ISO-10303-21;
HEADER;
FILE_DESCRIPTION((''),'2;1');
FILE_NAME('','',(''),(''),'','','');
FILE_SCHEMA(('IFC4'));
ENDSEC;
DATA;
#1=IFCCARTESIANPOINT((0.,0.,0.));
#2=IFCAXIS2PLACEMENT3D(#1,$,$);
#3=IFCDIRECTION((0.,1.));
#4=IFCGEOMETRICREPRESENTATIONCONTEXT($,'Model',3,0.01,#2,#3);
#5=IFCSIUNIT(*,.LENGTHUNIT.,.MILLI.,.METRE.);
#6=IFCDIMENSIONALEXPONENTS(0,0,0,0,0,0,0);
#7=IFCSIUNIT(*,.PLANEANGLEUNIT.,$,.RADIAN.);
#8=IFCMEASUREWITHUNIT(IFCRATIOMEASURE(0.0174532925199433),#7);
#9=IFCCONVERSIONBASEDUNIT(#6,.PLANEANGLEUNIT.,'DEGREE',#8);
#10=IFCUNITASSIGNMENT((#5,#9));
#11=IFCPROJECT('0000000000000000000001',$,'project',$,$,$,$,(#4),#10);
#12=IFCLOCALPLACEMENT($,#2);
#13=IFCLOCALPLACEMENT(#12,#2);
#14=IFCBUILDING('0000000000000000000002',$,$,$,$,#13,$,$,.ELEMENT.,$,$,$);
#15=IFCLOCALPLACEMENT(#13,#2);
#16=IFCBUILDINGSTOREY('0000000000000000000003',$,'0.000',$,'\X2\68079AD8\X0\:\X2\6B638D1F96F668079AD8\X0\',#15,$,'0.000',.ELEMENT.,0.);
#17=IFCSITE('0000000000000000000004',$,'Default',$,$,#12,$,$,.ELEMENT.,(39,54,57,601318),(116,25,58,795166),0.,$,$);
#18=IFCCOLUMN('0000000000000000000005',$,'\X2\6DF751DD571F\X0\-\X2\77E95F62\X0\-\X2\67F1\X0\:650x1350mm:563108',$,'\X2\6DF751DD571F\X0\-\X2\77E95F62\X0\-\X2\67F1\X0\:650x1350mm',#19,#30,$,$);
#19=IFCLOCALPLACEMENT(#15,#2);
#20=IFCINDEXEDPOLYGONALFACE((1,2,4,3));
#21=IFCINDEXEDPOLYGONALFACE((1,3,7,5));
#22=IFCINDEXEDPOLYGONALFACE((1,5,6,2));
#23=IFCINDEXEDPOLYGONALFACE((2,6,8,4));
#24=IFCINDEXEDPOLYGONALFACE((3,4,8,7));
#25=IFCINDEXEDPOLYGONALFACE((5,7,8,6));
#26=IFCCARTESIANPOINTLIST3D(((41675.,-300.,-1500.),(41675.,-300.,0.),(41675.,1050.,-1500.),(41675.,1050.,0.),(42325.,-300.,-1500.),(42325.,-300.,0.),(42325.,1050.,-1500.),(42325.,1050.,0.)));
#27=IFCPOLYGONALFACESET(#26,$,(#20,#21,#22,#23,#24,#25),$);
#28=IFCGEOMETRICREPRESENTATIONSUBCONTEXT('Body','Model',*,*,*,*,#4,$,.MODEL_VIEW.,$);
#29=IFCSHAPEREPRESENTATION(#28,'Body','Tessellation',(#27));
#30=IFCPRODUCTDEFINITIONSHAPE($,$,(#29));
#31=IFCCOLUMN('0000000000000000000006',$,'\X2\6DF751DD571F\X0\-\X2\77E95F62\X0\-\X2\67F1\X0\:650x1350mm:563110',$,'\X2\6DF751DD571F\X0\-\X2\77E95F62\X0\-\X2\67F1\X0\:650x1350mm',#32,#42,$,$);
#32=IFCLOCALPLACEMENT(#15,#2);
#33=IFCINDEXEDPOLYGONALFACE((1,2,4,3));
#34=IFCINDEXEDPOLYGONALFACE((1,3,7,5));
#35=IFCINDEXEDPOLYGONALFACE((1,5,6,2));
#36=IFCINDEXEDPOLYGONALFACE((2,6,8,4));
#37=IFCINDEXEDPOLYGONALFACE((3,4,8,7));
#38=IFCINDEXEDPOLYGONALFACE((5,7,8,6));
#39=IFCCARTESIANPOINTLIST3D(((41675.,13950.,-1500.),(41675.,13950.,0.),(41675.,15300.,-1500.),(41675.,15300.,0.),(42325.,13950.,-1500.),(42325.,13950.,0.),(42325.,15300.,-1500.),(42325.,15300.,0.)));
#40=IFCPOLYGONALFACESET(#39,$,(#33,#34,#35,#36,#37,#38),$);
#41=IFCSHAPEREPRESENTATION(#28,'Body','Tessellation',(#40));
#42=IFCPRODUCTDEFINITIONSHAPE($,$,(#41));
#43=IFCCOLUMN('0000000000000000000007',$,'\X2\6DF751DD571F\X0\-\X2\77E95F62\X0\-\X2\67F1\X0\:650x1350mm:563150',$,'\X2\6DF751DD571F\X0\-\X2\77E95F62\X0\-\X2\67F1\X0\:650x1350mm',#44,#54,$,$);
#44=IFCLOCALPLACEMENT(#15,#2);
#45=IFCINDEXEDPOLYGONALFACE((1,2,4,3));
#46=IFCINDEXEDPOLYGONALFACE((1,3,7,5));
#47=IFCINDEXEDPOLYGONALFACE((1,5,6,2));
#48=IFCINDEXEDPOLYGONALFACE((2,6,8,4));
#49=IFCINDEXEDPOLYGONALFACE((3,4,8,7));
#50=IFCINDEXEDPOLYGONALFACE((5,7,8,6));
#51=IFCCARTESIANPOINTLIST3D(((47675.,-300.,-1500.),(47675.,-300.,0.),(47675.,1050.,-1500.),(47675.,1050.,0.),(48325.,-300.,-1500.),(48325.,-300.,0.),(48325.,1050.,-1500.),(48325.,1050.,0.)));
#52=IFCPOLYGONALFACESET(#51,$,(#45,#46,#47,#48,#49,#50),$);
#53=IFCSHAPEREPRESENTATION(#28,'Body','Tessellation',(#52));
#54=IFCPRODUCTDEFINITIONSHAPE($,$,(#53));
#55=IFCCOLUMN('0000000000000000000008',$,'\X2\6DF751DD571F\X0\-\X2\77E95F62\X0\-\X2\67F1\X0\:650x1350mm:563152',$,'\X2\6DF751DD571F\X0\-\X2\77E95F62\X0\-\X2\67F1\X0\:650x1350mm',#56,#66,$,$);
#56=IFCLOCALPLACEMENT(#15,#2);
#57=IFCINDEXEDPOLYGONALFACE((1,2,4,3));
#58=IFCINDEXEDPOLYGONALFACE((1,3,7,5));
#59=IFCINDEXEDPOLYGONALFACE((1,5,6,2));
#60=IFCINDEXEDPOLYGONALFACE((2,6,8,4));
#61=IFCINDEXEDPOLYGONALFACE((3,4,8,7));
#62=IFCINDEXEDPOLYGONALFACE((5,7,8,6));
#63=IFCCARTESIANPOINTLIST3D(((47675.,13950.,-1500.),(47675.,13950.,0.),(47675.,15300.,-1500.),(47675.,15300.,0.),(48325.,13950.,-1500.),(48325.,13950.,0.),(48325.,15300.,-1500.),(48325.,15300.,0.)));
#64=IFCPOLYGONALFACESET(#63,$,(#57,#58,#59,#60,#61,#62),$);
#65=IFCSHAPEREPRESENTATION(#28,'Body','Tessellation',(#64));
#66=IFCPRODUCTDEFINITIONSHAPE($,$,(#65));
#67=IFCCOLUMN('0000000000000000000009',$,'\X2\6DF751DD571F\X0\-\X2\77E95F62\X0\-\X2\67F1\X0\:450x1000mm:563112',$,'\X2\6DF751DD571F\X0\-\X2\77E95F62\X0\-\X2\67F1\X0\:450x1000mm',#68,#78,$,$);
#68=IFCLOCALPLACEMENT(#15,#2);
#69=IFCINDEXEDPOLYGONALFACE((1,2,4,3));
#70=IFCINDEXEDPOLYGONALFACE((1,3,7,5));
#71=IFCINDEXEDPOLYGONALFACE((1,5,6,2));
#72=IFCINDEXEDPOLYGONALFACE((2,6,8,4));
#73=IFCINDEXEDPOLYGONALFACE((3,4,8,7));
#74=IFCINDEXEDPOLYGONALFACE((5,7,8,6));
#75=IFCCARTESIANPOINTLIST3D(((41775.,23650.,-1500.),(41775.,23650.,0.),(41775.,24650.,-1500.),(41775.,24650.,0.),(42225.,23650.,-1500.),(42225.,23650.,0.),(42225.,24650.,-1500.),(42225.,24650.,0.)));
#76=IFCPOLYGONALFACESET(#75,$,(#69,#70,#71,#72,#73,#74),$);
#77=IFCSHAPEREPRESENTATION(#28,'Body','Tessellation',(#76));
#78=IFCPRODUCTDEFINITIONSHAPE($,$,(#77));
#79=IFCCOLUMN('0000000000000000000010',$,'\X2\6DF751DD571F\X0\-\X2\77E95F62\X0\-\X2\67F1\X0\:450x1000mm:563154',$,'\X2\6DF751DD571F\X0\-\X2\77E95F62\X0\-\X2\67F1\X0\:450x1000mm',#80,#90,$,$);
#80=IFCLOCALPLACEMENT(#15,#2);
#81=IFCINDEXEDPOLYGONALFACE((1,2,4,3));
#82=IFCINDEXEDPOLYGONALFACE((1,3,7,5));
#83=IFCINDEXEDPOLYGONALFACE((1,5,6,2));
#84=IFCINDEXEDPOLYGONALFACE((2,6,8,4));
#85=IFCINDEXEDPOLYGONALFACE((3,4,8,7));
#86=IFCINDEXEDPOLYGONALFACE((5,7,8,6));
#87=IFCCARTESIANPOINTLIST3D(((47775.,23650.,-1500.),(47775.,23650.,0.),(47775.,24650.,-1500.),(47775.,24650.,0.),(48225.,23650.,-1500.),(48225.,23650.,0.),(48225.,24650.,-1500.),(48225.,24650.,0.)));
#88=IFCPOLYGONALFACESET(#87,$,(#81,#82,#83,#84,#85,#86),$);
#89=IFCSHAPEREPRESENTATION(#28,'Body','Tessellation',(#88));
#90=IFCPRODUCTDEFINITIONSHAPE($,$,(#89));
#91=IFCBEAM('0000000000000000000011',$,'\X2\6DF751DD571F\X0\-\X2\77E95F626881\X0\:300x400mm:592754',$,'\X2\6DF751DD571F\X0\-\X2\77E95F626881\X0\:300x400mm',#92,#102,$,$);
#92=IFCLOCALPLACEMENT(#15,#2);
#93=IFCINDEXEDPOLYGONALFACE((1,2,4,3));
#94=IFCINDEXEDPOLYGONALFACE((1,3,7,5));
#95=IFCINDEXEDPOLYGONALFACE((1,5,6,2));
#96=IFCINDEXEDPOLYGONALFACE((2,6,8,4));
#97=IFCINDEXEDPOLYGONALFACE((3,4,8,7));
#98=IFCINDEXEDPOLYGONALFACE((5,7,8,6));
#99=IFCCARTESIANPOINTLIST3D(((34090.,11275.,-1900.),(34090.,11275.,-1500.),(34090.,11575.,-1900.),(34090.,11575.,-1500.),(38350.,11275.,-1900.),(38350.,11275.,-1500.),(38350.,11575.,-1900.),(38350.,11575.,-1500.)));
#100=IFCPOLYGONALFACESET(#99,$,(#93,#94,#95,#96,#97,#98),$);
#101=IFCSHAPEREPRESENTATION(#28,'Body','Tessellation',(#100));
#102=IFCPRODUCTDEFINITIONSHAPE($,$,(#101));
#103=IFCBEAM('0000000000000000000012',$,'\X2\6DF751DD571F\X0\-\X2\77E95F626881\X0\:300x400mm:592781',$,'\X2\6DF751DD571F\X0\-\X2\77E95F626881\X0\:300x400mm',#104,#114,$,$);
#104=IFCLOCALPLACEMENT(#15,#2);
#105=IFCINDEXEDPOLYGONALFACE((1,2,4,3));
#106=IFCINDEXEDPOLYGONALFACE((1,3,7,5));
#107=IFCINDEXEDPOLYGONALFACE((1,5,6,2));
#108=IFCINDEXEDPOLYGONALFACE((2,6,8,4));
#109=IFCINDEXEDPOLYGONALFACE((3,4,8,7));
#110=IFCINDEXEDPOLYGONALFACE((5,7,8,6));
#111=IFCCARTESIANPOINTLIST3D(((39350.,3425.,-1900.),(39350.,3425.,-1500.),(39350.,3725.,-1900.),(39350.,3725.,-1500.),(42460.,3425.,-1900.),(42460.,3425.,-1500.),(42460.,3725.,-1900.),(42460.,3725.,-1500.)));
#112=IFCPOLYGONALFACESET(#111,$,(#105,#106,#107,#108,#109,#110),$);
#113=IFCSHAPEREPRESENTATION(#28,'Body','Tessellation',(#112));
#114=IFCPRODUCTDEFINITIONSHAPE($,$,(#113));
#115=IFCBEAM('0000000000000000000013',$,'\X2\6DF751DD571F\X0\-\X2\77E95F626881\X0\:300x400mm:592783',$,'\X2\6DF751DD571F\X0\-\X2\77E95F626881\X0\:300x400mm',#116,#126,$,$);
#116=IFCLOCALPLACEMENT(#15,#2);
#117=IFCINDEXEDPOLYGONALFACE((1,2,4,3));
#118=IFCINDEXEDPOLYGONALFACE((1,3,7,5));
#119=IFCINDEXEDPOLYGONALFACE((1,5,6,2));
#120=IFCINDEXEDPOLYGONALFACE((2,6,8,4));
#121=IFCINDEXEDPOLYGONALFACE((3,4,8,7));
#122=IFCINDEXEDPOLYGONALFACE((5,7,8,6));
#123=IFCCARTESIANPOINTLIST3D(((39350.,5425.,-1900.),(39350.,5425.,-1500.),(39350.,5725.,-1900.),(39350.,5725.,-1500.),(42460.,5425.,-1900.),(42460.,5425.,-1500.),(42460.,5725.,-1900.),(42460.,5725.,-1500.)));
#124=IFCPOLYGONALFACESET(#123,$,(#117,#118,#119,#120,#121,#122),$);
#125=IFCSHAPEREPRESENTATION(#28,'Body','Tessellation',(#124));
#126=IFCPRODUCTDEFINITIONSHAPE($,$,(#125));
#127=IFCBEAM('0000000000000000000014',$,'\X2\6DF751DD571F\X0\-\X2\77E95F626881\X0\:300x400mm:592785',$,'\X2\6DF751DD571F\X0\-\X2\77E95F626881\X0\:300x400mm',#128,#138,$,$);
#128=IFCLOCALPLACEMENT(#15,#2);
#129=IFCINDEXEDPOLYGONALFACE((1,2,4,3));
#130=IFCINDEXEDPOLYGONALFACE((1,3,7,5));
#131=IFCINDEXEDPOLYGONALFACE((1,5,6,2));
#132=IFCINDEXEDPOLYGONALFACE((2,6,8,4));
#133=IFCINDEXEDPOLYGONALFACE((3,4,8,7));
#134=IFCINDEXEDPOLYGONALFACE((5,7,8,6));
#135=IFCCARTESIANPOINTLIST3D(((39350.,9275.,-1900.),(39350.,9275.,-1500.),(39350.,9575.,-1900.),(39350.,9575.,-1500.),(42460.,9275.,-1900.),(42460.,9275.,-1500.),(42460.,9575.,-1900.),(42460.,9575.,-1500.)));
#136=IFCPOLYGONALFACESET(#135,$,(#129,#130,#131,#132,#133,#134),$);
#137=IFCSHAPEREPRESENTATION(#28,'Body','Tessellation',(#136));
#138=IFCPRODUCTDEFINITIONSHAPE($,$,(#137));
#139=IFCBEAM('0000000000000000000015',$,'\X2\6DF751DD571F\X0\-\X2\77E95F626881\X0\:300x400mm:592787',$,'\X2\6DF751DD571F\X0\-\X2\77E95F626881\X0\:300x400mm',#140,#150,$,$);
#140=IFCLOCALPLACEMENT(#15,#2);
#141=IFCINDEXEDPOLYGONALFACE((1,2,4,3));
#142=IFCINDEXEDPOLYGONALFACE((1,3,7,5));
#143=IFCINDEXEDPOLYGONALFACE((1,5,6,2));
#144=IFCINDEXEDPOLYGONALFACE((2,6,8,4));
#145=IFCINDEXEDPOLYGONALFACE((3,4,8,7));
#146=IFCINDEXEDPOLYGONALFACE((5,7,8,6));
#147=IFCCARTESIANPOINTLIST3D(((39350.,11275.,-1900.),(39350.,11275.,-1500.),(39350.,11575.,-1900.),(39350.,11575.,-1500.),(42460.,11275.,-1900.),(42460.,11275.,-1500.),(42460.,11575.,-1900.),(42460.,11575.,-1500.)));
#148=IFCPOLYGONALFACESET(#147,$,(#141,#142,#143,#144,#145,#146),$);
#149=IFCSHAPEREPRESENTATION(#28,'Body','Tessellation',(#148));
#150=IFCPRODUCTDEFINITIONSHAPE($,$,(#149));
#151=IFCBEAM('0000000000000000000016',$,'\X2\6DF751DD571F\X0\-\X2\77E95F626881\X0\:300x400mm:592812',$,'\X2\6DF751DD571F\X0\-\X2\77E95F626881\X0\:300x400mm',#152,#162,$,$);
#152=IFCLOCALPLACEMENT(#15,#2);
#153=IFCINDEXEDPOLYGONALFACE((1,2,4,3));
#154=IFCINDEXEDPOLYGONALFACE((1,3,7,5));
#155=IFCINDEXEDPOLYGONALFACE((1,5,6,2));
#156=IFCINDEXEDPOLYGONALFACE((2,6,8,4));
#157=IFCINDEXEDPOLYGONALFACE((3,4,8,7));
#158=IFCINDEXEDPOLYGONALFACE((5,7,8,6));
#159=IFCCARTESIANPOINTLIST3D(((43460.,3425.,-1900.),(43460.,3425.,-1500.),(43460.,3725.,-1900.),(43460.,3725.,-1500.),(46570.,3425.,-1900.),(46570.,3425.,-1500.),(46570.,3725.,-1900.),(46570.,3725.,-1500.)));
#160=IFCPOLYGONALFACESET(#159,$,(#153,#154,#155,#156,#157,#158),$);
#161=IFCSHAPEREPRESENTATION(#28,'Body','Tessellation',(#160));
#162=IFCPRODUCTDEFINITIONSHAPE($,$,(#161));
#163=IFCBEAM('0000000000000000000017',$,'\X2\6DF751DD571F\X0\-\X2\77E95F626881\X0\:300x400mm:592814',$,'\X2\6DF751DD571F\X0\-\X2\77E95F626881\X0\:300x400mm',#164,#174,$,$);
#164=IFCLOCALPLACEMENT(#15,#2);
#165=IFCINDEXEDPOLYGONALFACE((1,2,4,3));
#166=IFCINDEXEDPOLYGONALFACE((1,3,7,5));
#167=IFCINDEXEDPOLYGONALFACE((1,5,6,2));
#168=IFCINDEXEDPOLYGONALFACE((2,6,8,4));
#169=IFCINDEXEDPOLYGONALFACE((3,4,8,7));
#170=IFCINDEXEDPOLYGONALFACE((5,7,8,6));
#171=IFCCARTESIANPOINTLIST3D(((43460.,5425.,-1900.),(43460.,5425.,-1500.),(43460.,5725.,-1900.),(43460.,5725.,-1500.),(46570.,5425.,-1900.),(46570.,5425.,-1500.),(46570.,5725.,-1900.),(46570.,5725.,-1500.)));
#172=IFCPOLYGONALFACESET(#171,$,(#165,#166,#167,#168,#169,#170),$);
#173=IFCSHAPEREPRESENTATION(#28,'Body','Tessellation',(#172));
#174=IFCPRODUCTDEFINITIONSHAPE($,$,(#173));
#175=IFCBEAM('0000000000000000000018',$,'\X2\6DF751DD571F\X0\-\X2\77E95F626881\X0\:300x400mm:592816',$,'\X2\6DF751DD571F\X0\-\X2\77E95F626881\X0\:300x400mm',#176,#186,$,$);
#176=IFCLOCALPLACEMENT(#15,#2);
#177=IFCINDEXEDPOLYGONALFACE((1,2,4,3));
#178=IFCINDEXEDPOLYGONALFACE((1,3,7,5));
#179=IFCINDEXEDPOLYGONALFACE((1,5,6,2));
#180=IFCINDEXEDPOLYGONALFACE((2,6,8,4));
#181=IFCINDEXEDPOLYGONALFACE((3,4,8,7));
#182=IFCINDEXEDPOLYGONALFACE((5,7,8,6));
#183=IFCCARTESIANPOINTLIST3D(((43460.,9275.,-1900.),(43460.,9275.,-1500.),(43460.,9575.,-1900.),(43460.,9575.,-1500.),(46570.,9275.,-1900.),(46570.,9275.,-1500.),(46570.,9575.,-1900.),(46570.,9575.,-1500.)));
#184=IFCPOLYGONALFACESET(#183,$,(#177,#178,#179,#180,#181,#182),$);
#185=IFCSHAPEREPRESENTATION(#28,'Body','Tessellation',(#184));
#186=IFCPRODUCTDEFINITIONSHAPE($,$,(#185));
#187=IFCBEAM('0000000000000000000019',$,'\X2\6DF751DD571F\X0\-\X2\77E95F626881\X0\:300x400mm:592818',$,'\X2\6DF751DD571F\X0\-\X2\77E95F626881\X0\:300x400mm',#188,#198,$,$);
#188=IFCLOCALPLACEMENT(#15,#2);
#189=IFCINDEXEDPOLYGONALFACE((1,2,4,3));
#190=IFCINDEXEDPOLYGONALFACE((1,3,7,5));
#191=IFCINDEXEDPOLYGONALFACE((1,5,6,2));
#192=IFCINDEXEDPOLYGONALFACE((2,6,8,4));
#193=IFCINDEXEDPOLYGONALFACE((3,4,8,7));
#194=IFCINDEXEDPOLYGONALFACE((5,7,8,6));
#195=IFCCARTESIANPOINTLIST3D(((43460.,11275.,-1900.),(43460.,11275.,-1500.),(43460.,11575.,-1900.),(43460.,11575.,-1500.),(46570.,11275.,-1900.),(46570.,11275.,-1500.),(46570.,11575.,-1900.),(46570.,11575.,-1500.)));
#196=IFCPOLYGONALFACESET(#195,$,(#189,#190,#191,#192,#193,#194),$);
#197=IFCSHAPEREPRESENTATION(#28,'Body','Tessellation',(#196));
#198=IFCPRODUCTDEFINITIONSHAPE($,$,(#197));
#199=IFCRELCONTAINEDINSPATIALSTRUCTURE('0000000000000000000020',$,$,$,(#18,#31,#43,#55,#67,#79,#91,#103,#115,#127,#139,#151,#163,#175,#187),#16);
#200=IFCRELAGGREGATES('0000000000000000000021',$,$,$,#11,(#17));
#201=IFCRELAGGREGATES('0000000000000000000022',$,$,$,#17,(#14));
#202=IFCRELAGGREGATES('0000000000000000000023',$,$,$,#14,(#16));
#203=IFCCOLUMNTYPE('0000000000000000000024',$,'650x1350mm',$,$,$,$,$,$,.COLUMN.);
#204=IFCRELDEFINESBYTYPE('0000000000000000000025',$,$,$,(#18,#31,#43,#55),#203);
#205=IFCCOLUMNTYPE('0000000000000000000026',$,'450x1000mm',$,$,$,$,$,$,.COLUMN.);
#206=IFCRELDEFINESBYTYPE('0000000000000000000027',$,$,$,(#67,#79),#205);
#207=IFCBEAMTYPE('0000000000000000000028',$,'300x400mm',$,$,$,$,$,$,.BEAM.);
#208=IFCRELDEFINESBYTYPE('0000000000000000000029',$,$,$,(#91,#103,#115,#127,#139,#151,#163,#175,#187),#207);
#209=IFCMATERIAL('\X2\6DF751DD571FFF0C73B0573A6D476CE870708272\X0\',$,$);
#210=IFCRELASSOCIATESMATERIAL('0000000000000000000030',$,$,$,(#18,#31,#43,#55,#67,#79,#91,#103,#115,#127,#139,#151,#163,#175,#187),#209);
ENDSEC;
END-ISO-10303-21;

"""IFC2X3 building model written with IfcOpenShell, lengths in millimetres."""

from ifc_helpers import new_model, entity, si_unit, converted_unit, direction, frame, frame_2d, origin, origin_2d_with_axis, place, context, subcontext, project, spatial, rectangle, extrude, source, transform, mapped, material, type_object, type_shapes, element, save


model = new_model("IFC2X3")

# Units and contexts
model_context = context("Model", 3, precision=0.01, world=origin(), true_north=direction((0.0, 1.0)))
body_context = subcontext(model_context, "Body", "Model", "MODEL_VIEW")
ifc_project = project(units=[si_unit("LENGTHUNIT", "METRE", prefix="MILLI"), converted_unit("PLANEANGLEUNIT", "DEGREE", entity("IfcRatioMeasure", 0.0174532925199433), si_unit("PLANEANGLEUNIT", "RADIAN"), dimensions=[0, 0, 0, 0, 0, 0, 0])], contexts=[model_context])

# Site, building, storey
site_placement = place(None, origin())
site = spatial("IfcSite", under=ifc_project, at=site_placement, Name="Default", CompositionType="ELEMENT", RefLatitude=(39, 54, 57, 601318), RefLongitude=(116, 25, 58, 795166), RefElevation=0.0)
building_placement = place(site_placement, origin())
building = spatial("IfcBuilding", under=site, at=building_placement, CompositionType="ELEMENT")
storey_placement = place(building_placement, origin())
storey = spatial("IfcBuildingStorey", under=building, at=storey_placement, Name="0.000", ObjectType="标高:正负零标高", LongName="0.000", CompositionType="ELEMENT", Elevation=0.0)

# Columns
ifc_material = material(Name="混凝土，现场浇注灰色")
column_type_1 = type_object("IfcColumnType", Name="650x1350mm", PredefinedType="COLUMN")
shared_shape_1 = source(origin(), body_context, "Body", "SweptSolid", [
    extrude(rectangle(XDim=1350.0, YDim=650.0, at=origin_2d_with_axis()), frame((0.0, 0.0, -1500.0), z_axis=(0.0, 0.0, 1.0), x_axis=(0.0, -1.0, 0.0)), (0.0, 0.0, 1.0), 1500.0),
])
type_shapes(column_type_1, [shared_shape_1])
for number, where, name in (
    (1, (42000.0, 375.0, 0.0), "混凝土-矩形-柱:650x1350mm:563108"),
    (2, (42000.0, 14625.0, 0.0), "混凝土-矩形-柱:650x1350mm:563110"),
    (3, (48000.0, 375.0, 0.0), "混凝土-矩形-柱:650x1350mm:563150"),
    (4, (48000.0, 14625.0, 0.0), "混凝土-矩形-柱:650x1350mm:563152"),
):
    element("IfcColumn", number, at=place(storey_placement, frame(where)), inside=storey, type_object=column_type_1, material=ifc_material, Name=name, ObjectType="混凝土-矩形-柱:650x1350mm", context=body_context, shape_type="MappedRepresentation", body=[
        mapped(shared_shape_1, transform((0.0, 0.0, 0.0), scale=1.0)),
    ])
column_type_2 = type_object("IfcColumnType", Name="450x1000mm", PredefinedType="COLUMN")
shared_shape_2 = source(origin(), body_context, "Body", "SweptSolid", [
    extrude(rectangle(XDim=1000.0, YDim=450.0, at=origin_2d_with_axis()), frame((0.0, 0.0, -1500.0), z_axis=(0.0, 0.0, 1.0), x_axis=(0.0, -1.0, 0.0)), (0.0, 0.0, 1.0), 1500.0),
])
type_shapes(column_type_2, [shared_shape_2])
for number, where, name in (
    (5, (42000.0, 24150.0, 0.0), "混凝土-矩形-柱:450x1000mm:563112"),
    (6, (48000.0, 24150.0, 0.0), "混凝土-矩形-柱:450x1000mm:563154"),
):
    element("IfcColumn", number, at=place(storey_placement, frame(where)), inside=storey, type_object=column_type_2, material=ifc_material, Name=name, ObjectType="混凝土-矩形-柱:450x1000mm", context=body_context, shape_type="MappedRepresentation", body=[
        mapped(shared_shape_2, transform((0.0, 0.0, 0.0), scale=1.0)),
    ])

# Beams
beam_type_1 = type_object("IfcBeamType", Name="300x400mm", PredefinedType="BEAM")
beam_1_placement = place(storey_placement, frame((38350.0, 11425.0, -1500.0), z_axis=(0.0, 0.0, 1.0), x_axis=(-1.0, 0.0, 0.0)))
element("IfcBeam", 7, at=beam_1_placement, inside=storey, type_object=beam_type_1, material=ifc_material, Name="混凝土-矩形梁:300x400mm:592754", ObjectType="混凝土-矩形梁:300x400mm", context=body_context, shape_type="SweptSolid", body=[
    extrude(rectangle(XDim=400.0, YDim=300.0, at=frame_2d((0.0, 0.0), x_axis=(1.0, 0.0))), frame((0.0, 0.0, -200.0), z_axis=(1.0, 0.0, 0.0), x_axis=(0.0, 0.0, -1.0)), (0.0, 0.0, 1.0), 4260.0),
])
beam_2_placement = place(storey_placement, frame((42460.0, 3575.0, -1500.0), z_axis=(0.0, 0.0, 1.0), x_axis=(-1.0, 0.0, 0.0)))
element("IfcBeam", 8, at=beam_2_placement, inside=storey, type_object=beam_type_1, material=ifc_material, Name="混凝土-矩形梁:300x400mm:592781", ObjectType="混凝土-矩形梁:300x400mm", context=body_context, shape_type="SweptSolid", body=[
    extrude(rectangle(XDim=400.0, YDim=300.0, at=frame_2d((0.0, 0.0), x_axis=(1.0, 0.0))), frame((0.0, 0.0, -200.0), z_axis=(1.0, 0.0, 0.0), x_axis=(0.0, 0.0, -1.0)), (0.0, 0.0, 1.0), 3110.0),
])
beam_3_placement = place(storey_placement, frame((42460.0, 5575.0, -1500.0), z_axis=(0.0, 0.0, 1.0), x_axis=(-1.0, 0.0, 0.0)))
element("IfcBeam", 9, at=beam_3_placement, inside=storey, type_object=beam_type_1, material=ifc_material, Name="混凝土-矩形梁:300x400mm:592783", ObjectType="混凝土-矩形梁:300x400mm", context=body_context, shape_type="SweptSolid", body=[
    extrude(rectangle(XDim=400.0, YDim=300.0, at=frame_2d((0.0, 0.0), x_axis=(1.0, 0.0))), frame((0.0, 0.0, -200.0), z_axis=(1.0, 0.0, 0.0), x_axis=(0.0, 0.0, -1.0)), (0.0, 0.0, 1.0), 3110.0),
])
beam_4_placement = place(storey_placement, frame((42460.0, 9425.0, -1500.0), z_axis=(0.0, 0.0, 1.0), x_axis=(-1.0, 0.0, 0.0)))
element("IfcBeam", 10, at=beam_4_placement, inside=storey, type_object=beam_type_1, material=ifc_material, Name="混凝土-矩形梁:300x400mm:592785", ObjectType="混凝土-矩形梁:300x400mm", context=body_context, shape_type="SweptSolid", body=[
    extrude(rectangle(XDim=400.0, YDim=300.0, at=frame_2d((0.0, 0.0), x_axis=(1.0, 0.0))), frame((0.0, 0.0, -200.0), z_axis=(1.0, 0.0, 0.0), x_axis=(0.0, 0.0, -1.0)), (0.0, 0.0, 1.0), 3110.0),
])
for number, where, z_axis, x_axis, name in (
    (11, (42460.0, 11425.0, -1500.0), (0.0, 0.0, 1.0), (-1.0, 0.0, 0.0), "混凝土-矩形梁:300x400mm:592787"),
    (12, (46570.0, 3575.0, -1500.0), (0.0, 0.0, 1.0), (-1.0, 0.0, 0.0), "混凝土-矩形梁:300x400mm:592812"),
):
    element("IfcBeam", number, at=place(storey_placement, frame(where, z_axis=z_axis, x_axis=x_axis)), inside=storey, type_object=beam_type_1, material=ifc_material, Name=name, ObjectType="混凝土-矩形梁:300x400mm", context=body_context, shape_type="SweptSolid", body=[
        extrude(rectangle(XDim=400.0, YDim=300.0, at=frame_2d((0.0, 0.0), x_axis=(1.0, 0.0))), frame((0.0, 0.0, -200.0), z_axis=(1.0, 0.0, 0.0), x_axis=(0.0, 0.0, -1.0)), (0.0, 0.0, 1.0), 3110.0),
    ])
beam_5_placement = place(storey_placement, frame((46570.0, 5575.0, -1500.0), z_axis=(0.0, 0.0, 1.0), x_axis=(-1.0, 0.0, 0.0)))
element("IfcBeam", 13, at=beam_5_placement, inside=storey, type_object=beam_type_1, material=ifc_material, Name="混凝土-矩形梁:300x400mm:592814", ObjectType="混凝土-矩形梁:300x400mm", context=body_context, shape_type="SweptSolid", body=[
    extrude(rectangle(XDim=400.0, YDim=300.0, at=frame_2d((0.0, 0.0), x_axis=(1.0, 0.0))), frame((0.0, 0.0, -200.0), z_axis=(1.0, 0.0, 0.0), x_axis=(0.0, 0.0, -1.0)), (0.0, 0.0, 1.0), 3110.0),
])
beam_6_placement = place(storey_placement, frame((46570.0, 9425.0, -1500.0), z_axis=(0.0, 0.0, 1.0), x_axis=(-1.0, 0.0, 0.0)))
element("IfcBeam", 14, at=beam_6_placement, inside=storey, type_object=beam_type_1, material=ifc_material, Name="混凝土-矩形梁:300x400mm:592816", ObjectType="混凝土-矩形梁:300x400mm", context=body_context, shape_type="SweptSolid", body=[
    extrude(rectangle(XDim=400.0, YDim=300.0, at=frame_2d((0.0, 0.0), x_axis=(1.0, 0.0))), frame((0.0, 0.0, -200.0), z_axis=(1.0, 0.0, 0.0), x_axis=(0.0, 0.0, -1.0)), (0.0, 0.0, 1.0), 3110.0),
])
beam_7_placement = place(storey_placement, frame((46570.0, 11425.0, -1500.0), z_axis=(0.0, 0.0, 1.0), x_axis=(-1.0, 0.0, 0.0)))
element("IfcBeam", 15, at=beam_7_placement, inside=storey, type_object=beam_type_1, material=ifc_material, Name="混凝土-矩形梁:300x400mm:592818", ObjectType="混凝土-矩形梁:300x400mm", context=body_context, shape_type="SweptSolid", body=[
    extrude(rectangle(XDim=400.0, YDim=300.0, at=frame_2d((0.0, 0.0), x_axis=(1.0, 0.0))), frame((0.0, 0.0, -200.0), z_axis=(1.0, 0.0, 0.0), x_axis=(0.0, 0.0, -1.0)), (0.0, 0.0, 1.0), 3110.0),
])

save(model, "model.ifc")
